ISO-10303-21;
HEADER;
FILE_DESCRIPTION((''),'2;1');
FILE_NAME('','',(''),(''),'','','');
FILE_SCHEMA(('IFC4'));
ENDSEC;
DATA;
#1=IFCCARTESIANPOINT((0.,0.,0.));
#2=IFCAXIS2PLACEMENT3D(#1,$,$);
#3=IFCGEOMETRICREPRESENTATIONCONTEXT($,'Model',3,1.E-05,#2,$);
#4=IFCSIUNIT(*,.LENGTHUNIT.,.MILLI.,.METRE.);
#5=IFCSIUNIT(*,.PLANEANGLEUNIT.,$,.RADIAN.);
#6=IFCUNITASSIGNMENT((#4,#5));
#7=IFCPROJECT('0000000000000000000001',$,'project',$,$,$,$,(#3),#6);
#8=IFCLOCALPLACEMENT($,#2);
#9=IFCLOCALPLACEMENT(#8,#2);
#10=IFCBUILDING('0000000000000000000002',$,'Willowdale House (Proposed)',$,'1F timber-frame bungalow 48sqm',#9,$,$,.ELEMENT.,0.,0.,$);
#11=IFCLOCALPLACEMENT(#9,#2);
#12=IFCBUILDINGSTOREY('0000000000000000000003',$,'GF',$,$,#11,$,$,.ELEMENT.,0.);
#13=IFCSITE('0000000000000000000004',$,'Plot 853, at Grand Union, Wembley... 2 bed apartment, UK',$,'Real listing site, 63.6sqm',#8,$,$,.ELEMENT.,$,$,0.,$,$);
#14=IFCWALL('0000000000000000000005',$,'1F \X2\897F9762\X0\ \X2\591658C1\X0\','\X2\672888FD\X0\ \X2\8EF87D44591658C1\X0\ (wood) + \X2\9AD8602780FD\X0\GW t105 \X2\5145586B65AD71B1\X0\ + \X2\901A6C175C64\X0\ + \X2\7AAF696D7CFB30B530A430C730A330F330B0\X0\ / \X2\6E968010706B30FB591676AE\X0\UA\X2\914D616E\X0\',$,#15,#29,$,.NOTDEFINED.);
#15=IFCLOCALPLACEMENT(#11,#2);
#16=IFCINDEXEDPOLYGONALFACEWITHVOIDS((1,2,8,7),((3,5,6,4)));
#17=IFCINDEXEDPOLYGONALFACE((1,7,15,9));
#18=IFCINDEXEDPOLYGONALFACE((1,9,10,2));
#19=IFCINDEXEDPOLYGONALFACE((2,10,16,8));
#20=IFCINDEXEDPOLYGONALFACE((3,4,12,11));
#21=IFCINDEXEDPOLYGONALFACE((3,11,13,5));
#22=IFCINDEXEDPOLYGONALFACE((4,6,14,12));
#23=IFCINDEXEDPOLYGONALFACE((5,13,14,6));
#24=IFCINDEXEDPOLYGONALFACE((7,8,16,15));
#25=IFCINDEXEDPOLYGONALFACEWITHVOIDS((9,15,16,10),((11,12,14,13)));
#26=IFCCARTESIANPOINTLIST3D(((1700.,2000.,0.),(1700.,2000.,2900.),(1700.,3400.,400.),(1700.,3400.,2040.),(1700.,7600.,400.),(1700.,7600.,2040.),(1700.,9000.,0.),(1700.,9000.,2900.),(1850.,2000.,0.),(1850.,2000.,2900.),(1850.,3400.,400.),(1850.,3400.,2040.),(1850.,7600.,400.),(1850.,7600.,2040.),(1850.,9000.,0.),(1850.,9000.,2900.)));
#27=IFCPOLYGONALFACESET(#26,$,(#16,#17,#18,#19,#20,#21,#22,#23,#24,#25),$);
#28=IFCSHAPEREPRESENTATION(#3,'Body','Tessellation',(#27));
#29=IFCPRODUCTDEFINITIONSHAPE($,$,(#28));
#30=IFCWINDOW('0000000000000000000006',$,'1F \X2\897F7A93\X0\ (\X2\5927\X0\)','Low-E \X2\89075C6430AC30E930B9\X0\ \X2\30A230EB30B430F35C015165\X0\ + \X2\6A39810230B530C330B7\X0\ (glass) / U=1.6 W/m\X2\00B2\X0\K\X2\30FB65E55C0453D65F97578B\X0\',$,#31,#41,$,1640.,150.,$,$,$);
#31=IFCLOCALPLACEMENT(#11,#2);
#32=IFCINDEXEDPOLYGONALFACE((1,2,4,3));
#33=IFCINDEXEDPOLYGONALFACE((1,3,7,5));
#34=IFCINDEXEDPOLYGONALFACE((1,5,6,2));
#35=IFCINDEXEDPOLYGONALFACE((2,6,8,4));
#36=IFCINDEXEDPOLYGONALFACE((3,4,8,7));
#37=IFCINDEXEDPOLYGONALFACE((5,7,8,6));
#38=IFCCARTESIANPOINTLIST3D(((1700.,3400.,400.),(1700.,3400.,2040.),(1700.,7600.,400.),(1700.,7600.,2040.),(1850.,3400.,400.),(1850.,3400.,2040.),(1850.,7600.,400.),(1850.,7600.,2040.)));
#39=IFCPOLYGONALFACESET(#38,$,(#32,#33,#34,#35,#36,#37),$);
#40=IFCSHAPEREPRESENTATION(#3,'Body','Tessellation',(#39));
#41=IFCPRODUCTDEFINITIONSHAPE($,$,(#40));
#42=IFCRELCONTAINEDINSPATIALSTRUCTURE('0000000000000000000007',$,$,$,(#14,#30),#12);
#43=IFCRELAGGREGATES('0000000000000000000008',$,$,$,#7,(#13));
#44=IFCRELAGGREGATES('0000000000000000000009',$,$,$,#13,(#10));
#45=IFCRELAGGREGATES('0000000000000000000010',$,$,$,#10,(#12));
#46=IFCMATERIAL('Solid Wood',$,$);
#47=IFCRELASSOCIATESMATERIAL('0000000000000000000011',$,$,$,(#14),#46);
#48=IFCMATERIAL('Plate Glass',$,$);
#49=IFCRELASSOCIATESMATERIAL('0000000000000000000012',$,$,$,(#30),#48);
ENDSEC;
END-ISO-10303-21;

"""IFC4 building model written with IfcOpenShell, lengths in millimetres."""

from ifc_helpers import new_model, si_unit, frame, frame_2d, origin, place, context, project, spatial, rectangle, extrude, material, element, fill, save


model = new_model("IFC4")

# Units and contexts
model_context = context("Model", 3, precision=1e-05, world=origin())
ifc_project = project(units=[si_unit("LENGTHUNIT", "METRE", prefix="MILLI"), si_unit("PLANEANGLEUNIT", "RADIAN")], contexts=[model_context])

# Site, building, storey
site_placement = place(None, origin())
site = spatial("IfcSite", under=ifc_project, at=site_placement, Name="Plot 853, at Grand Union, Wembley... 2 bed apartment, UK", ObjectType="Real listing site, 63.6sqm", CompositionType="ELEMENT", RefElevation=0.0)
building_placement = place(site_placement, origin())
building = spatial("IfcBuilding", under=site, at=building_placement, Name="Willowdale House (Proposed)", ObjectType="1F timber-frame bungalow 48sqm", CompositionType="ELEMENT", ElevationOfRefHeight=0.0, ElevationOfTerrain=0.0)
storey_placement = place(building_placement, origin())
storey = spatial("IfcBuildingStorey", under=building, at=storey_placement, Name="GF", CompositionType="ELEMENT", Elevation=0.0)

# Shared definitions
ifc_material_1 = material(Name="Solid Wood")

# Shared definitions
ifc_material_2 = material(Name="Plate Glass")

# Wall, opening, window
wall_1_placement = place(storey_placement, frame((850.0, 1000.0, 0.0)))
wall_1 = element("IfcWall", 1, at=wall_1_placement, inside=storey, material=ifc_material_1, Name="1F 西面 外壁", Description="木製 軸組外壁 (wood) + 高性能GW t105 充填断熱 + 通気層 + 窯業系サイディング / 準耐火・外皮UA配慮", PredefinedType="NOTDEFINED", context=model_context, shape_type="SweptSolid", body=[
    extrude(rectangle(XDim=150.0, YDim=7000.0, at=frame_2d((75.0, 3500.0))), frame((850.0, 1000.0, 0.0)), (0.0, 0.0, 1.0), 2900.0),
])
opening_1_placement = place(storey_placement, frame((850.0, 1700.0, 200.0)))
opening_1 = element("IfcOpeningElement", 2, at=opening_1_placement, cuts=wall_1, PredefinedType="NOTDEFINED", context=model_context, shape_type="SweptSolid", body=[
    extrude(rectangle(XDim=150.0, YDim=4200.0, at=frame_2d((75.0, 2100.0))), frame((850.0, 1700.0, 200.0)), (0.0, 0.0, 1.0), 1640.0),
])
window_1_placement = place(storey_placement, frame((850.0, 1700.0, 200.0)))
window_1 = element("IfcWindow", 3, at=window_1_placement, inside=storey, material=ifc_material_2, Name="1F 西窓 (大)", Description="Low-E 複層ガラス アルゴン封入 + 樹脂サッシ (glass) / U=1.6 W/m²K・日射取得型", OverallHeight=1640.0, OverallWidth=150.0, context=model_context, shape_type="SweptSolid", body=[
    extrude(rectangle(XDim=150.0, YDim=4200.0, at=frame_2d((75.0, 2100.0))), frame((850.0, 1700.0, 200.0)), (0.0, 0.0, 1.0), 1640.0),
])
fill(opening_1, window_1)

save(model, "model.ifc")
